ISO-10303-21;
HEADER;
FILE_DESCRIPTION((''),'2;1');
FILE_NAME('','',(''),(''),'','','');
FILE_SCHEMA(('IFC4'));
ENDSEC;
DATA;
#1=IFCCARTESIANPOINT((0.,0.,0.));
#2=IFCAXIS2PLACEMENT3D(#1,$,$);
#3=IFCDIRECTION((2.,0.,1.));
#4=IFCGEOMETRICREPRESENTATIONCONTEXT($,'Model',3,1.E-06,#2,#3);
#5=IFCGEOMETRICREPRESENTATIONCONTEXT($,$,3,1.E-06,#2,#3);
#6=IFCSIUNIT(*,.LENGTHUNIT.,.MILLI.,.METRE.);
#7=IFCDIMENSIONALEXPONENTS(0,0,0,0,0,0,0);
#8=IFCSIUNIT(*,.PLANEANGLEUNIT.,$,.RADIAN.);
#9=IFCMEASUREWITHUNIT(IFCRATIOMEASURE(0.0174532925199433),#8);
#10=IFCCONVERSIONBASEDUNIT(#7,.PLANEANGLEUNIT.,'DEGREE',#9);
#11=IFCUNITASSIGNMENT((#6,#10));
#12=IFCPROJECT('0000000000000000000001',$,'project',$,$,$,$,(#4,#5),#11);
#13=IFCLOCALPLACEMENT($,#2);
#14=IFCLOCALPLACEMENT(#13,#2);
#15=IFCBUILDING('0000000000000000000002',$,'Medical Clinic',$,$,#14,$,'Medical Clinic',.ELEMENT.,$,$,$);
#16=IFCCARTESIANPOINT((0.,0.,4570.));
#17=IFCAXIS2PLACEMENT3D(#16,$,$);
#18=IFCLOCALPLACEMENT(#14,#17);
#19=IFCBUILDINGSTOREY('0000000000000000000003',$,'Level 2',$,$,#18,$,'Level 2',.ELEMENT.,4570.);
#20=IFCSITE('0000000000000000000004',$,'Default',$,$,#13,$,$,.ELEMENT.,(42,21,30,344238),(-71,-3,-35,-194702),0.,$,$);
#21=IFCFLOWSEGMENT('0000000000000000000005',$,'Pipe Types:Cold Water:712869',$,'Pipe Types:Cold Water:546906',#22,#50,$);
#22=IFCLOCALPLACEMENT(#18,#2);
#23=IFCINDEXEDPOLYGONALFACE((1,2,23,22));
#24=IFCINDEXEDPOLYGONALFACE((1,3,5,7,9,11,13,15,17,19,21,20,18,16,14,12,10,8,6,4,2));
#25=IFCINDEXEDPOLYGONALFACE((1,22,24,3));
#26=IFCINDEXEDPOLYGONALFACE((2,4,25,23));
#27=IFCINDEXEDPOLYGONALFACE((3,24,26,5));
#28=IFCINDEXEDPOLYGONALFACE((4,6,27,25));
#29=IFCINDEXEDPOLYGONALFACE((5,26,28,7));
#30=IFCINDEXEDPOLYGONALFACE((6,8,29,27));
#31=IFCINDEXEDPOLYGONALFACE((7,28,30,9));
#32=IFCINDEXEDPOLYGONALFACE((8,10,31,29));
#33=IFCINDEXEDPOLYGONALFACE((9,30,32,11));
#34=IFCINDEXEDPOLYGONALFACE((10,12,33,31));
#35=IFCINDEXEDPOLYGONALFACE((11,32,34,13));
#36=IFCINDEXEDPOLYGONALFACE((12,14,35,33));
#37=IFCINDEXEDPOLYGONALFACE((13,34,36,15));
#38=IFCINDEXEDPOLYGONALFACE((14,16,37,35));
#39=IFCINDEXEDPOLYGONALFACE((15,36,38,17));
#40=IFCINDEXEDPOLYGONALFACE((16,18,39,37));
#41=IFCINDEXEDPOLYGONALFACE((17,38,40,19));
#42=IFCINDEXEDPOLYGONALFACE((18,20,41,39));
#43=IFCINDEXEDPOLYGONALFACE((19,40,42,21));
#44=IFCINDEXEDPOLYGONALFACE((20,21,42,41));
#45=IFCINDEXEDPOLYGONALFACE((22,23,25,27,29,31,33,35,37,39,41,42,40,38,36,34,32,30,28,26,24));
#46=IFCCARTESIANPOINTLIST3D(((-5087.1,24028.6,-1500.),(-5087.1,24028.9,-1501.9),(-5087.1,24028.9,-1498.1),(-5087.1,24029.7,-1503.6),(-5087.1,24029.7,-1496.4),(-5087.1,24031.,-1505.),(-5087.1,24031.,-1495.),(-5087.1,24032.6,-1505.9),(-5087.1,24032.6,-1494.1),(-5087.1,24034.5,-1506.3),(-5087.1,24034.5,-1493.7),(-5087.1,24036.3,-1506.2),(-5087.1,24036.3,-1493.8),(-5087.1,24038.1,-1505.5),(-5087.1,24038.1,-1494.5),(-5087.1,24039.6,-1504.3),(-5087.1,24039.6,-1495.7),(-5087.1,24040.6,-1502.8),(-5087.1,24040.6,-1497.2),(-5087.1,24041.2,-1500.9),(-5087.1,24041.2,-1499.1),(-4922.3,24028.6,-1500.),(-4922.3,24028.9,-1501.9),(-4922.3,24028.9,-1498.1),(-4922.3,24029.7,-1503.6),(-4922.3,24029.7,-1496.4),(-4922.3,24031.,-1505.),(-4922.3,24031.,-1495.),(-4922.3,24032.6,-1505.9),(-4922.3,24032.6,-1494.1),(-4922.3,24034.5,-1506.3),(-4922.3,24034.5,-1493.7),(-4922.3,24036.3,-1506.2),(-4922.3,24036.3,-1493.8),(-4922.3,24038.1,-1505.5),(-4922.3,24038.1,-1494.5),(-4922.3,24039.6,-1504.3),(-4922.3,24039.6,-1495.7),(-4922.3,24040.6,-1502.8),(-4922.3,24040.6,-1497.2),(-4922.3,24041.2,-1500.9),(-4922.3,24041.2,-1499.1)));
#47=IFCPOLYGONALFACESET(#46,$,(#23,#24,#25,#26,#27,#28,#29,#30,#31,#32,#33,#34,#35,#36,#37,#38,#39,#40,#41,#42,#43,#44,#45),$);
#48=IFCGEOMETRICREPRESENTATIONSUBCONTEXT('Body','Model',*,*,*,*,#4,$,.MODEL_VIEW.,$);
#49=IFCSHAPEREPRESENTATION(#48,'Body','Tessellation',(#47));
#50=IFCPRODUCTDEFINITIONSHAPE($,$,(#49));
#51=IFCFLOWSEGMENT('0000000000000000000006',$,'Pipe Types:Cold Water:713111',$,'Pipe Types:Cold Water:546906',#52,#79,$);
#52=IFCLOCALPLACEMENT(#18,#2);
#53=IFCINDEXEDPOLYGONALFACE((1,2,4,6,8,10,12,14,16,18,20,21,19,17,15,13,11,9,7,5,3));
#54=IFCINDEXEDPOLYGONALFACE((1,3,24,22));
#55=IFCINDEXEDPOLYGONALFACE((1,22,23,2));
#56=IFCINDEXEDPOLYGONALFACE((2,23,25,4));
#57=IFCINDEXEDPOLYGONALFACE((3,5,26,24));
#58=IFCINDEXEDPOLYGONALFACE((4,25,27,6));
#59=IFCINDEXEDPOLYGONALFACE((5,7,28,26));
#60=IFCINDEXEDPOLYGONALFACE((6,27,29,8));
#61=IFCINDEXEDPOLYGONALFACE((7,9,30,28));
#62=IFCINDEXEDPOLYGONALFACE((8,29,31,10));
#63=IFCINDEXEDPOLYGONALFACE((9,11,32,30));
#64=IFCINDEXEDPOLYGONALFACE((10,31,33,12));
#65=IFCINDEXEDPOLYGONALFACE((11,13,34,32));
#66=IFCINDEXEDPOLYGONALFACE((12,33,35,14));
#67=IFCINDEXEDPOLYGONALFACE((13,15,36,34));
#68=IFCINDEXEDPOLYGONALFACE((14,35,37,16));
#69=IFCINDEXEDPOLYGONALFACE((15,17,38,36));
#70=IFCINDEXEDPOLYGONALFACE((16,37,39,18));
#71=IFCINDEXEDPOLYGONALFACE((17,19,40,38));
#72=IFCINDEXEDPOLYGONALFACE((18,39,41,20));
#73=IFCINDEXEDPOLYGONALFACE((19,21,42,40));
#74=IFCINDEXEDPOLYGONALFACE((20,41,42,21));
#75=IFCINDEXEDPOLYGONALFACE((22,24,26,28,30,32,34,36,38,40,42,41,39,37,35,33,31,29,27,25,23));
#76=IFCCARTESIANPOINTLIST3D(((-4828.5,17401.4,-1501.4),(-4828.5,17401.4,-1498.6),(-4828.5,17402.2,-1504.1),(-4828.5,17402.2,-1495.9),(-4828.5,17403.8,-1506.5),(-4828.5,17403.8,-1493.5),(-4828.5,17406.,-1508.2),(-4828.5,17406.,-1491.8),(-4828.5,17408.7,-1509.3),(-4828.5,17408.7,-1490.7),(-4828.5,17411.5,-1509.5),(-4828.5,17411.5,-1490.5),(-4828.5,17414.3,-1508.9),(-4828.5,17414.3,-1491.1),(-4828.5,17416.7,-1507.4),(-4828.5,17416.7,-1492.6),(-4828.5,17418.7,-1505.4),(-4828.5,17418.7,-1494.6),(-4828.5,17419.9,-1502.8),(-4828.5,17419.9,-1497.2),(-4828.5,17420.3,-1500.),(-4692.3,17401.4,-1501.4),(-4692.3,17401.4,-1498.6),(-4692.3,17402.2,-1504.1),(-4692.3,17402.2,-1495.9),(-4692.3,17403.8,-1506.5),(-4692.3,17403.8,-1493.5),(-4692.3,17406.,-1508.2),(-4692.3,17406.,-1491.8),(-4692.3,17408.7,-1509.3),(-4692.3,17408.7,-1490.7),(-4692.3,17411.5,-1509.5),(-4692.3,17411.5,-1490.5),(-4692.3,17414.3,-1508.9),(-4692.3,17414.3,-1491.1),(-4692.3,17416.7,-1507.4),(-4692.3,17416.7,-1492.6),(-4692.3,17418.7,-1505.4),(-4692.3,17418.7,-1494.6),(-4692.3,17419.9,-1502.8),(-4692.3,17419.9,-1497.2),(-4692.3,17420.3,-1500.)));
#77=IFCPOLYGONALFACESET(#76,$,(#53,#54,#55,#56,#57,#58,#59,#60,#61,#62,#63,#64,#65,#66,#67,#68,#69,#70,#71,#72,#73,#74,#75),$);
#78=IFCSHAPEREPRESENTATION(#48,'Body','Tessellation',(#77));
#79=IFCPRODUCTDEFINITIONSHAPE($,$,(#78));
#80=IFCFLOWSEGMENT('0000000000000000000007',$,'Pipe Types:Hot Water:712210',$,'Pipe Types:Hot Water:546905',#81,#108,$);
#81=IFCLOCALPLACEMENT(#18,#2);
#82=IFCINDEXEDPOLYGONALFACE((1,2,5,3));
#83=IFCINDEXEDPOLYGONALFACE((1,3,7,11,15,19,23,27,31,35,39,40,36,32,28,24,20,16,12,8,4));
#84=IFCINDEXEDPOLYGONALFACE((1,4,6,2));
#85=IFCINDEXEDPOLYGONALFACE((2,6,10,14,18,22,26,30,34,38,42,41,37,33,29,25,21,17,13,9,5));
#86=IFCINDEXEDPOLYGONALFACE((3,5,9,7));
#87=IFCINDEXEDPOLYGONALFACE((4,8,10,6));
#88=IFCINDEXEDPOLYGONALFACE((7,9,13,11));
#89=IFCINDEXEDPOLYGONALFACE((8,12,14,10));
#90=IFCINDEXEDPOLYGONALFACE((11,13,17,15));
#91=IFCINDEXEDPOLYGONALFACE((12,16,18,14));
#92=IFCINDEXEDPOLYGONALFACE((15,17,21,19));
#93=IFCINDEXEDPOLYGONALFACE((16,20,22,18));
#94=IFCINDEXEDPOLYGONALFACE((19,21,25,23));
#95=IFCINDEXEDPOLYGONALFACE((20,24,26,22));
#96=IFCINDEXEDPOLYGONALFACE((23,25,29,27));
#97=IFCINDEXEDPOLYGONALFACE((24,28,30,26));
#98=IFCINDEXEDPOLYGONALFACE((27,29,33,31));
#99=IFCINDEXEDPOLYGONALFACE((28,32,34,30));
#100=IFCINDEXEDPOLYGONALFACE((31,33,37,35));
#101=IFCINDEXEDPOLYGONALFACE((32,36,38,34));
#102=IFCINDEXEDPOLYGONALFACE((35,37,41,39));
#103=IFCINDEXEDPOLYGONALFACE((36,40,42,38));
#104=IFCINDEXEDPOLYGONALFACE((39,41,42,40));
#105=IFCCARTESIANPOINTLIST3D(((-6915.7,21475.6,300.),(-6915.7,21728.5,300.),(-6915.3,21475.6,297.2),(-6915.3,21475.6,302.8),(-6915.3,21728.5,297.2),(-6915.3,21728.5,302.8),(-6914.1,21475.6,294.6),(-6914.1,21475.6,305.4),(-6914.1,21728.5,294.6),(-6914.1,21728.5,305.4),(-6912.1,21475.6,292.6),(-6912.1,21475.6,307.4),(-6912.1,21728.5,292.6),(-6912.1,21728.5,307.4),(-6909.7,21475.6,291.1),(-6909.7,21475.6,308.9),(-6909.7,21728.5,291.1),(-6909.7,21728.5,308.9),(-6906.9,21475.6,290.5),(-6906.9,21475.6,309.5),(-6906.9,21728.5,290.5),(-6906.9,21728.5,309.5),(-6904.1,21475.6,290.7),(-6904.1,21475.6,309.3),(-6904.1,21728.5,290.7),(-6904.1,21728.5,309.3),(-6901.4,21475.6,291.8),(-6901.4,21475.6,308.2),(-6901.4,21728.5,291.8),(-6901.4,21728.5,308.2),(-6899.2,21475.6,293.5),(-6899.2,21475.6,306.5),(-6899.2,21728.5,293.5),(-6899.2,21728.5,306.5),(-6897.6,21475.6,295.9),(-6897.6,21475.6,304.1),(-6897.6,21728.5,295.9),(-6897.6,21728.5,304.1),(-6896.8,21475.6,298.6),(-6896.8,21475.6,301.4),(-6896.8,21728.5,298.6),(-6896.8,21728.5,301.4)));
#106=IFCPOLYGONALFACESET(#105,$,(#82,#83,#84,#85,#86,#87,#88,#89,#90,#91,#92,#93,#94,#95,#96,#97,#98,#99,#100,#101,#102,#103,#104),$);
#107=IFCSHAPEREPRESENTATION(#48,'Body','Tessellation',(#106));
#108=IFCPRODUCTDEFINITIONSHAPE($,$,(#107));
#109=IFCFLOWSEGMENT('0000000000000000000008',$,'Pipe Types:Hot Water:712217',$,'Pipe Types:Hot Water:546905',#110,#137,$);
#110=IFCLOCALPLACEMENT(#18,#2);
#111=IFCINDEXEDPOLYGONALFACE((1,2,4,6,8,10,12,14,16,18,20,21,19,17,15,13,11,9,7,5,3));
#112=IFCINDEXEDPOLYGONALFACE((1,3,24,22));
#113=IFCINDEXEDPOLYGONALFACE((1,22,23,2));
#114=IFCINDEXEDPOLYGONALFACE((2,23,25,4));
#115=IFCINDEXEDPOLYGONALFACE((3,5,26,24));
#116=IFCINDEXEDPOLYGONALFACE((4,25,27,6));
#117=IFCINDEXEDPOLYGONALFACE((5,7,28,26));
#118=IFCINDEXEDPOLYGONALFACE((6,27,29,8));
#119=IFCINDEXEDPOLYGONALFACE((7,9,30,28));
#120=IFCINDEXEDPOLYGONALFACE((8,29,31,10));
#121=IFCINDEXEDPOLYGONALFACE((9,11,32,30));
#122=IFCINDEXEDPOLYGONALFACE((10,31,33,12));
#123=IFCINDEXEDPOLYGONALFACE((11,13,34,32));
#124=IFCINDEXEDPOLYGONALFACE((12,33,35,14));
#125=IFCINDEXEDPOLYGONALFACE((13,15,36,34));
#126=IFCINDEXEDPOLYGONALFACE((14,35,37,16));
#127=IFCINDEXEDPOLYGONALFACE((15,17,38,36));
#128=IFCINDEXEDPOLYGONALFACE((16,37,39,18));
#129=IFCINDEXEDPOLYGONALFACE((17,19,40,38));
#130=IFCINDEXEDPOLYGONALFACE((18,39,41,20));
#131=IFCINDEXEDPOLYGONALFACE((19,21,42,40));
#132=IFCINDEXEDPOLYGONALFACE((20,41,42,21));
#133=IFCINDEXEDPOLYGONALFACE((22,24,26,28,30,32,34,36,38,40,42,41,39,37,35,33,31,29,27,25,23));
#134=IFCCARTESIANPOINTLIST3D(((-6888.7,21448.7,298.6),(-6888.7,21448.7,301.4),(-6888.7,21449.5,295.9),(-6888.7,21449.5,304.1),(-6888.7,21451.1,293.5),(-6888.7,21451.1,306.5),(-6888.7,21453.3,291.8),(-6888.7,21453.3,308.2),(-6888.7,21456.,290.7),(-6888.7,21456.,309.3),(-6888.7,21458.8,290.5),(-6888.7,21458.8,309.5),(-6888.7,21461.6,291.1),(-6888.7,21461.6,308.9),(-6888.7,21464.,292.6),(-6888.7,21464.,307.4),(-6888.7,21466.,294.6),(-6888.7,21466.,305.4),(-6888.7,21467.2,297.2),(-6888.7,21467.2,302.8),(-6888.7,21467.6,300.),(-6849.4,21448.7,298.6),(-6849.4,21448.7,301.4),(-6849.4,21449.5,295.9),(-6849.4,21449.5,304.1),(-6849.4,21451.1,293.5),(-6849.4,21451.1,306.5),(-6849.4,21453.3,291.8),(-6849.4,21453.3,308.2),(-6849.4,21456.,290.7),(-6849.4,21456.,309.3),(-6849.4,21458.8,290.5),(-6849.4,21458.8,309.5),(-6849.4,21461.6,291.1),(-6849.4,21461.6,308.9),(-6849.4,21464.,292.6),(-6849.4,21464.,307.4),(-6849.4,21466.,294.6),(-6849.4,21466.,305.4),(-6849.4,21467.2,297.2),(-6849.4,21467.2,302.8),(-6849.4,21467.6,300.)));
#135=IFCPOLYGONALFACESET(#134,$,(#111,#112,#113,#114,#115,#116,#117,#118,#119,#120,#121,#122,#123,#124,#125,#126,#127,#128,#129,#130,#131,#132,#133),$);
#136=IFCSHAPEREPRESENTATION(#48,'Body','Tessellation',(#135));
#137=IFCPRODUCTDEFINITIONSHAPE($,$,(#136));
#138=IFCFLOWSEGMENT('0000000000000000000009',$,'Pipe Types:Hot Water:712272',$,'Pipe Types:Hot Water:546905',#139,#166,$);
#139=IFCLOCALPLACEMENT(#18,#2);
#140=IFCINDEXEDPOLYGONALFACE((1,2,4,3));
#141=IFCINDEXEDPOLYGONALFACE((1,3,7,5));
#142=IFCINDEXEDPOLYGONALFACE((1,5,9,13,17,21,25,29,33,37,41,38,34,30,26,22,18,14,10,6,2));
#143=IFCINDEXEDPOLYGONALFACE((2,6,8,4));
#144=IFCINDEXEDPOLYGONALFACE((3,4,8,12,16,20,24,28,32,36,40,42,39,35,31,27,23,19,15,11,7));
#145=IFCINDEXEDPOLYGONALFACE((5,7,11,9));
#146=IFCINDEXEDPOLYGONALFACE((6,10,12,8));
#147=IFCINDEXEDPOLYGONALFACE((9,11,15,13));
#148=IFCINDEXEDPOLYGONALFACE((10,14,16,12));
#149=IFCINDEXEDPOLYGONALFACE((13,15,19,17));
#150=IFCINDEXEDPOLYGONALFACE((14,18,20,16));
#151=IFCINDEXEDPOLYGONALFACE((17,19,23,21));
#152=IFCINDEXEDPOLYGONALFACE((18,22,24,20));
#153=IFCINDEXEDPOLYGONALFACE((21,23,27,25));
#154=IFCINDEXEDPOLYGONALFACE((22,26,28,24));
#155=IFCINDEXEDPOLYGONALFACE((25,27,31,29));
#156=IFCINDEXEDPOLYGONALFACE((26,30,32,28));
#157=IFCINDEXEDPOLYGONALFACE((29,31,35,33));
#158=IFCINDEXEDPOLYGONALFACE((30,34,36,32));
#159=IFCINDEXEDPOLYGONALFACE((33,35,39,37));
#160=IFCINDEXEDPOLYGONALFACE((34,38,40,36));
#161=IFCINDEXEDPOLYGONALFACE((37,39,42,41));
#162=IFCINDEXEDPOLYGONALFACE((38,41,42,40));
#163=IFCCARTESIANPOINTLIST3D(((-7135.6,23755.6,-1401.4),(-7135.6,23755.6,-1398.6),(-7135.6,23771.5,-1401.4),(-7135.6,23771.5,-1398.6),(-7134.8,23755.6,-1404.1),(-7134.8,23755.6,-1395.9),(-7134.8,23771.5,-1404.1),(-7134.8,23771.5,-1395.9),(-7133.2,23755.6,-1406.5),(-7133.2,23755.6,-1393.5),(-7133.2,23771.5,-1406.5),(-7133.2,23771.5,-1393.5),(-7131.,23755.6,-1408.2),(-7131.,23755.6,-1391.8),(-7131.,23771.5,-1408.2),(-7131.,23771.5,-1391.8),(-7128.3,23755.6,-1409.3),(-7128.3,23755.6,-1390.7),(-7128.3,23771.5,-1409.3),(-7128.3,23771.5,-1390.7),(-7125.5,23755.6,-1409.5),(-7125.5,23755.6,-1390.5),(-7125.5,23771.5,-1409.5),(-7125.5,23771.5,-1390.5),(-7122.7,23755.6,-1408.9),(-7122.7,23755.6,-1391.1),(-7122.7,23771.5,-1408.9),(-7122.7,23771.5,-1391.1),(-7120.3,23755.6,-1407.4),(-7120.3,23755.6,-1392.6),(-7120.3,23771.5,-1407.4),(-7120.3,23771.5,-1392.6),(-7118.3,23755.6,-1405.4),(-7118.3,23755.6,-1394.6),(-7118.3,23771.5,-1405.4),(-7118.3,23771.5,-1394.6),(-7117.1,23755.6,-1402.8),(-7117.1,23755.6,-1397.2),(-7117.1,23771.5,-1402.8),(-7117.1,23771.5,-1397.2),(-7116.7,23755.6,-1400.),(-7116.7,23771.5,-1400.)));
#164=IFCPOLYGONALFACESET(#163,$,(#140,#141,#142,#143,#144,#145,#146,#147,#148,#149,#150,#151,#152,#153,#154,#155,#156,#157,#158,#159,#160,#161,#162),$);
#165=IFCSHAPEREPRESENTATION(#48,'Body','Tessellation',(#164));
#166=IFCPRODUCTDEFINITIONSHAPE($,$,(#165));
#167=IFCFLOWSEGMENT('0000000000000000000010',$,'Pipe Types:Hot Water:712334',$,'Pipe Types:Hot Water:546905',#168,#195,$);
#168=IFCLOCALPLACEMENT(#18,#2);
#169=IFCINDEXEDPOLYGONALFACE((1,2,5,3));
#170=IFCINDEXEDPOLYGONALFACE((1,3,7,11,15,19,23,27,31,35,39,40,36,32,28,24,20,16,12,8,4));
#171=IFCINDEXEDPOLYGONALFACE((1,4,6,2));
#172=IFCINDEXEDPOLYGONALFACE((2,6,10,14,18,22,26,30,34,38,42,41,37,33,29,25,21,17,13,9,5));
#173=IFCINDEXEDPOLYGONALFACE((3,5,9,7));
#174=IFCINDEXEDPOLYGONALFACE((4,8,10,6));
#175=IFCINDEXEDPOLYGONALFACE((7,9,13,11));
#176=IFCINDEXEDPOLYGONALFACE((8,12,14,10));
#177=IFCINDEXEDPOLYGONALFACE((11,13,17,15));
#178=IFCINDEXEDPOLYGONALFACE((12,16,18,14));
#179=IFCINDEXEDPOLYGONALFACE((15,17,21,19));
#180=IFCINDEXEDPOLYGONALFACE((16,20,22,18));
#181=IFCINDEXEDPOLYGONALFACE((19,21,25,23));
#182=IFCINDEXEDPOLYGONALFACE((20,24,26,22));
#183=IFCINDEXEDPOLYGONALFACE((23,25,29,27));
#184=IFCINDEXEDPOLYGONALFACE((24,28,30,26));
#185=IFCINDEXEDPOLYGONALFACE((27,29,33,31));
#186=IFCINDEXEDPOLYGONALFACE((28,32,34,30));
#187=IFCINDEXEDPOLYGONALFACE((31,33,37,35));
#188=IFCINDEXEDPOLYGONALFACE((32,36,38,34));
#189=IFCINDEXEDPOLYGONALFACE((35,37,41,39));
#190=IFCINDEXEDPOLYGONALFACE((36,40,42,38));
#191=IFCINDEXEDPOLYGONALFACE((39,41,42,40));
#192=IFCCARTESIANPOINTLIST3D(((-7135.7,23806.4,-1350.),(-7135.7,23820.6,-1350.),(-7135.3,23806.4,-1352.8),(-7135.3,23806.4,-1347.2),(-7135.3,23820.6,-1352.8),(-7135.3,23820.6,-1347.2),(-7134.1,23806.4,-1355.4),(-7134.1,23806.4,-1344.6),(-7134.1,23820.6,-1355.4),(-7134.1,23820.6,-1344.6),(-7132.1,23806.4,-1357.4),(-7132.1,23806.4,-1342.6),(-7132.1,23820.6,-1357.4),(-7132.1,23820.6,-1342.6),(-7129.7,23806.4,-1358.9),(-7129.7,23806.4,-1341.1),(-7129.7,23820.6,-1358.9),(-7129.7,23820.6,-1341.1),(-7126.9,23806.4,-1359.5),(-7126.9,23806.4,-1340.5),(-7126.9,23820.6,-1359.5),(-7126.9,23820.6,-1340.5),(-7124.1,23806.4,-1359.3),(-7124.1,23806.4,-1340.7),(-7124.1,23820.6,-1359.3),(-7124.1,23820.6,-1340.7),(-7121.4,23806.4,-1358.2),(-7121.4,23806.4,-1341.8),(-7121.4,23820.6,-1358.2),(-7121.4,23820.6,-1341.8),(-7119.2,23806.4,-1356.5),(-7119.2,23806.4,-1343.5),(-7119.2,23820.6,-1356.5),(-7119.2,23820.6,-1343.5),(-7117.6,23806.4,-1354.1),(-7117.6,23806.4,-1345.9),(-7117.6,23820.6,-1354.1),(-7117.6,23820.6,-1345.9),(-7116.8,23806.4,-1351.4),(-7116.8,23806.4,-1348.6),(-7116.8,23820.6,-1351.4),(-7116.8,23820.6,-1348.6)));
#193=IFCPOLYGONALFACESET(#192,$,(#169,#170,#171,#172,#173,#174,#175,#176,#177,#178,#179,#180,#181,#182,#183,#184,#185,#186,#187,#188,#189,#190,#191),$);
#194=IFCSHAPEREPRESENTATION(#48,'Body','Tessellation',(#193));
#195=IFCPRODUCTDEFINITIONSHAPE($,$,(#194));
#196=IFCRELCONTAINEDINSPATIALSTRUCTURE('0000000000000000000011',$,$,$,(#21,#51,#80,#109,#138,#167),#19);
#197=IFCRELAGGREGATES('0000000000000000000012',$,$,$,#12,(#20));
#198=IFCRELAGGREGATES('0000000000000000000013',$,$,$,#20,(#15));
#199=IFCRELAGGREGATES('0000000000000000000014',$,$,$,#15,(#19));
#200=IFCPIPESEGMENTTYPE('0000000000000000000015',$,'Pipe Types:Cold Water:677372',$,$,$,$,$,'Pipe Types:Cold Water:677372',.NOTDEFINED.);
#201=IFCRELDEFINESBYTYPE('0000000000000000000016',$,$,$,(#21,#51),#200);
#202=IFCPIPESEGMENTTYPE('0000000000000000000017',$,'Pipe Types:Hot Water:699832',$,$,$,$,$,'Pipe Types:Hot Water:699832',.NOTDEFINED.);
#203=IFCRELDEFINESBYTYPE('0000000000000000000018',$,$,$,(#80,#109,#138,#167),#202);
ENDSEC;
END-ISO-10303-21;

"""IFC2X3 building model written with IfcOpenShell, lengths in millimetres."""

from ifc_helpers import new_model, entity, si_unit, converted_unit, direction, frame, frame_2d, origin, origin_2d_with_axis, place, context, subcontext, project, spatial, circle, extrude, type_object, element, save


model = new_model("IFC2X3")

# Units and contexts
model_context = context("Model", 3, precision=1e-06, world=origin(), true_north=direction((2.0, 0.0, 1.0)))
context_of_model = context(None, 3, precision=1e-06, world=origin(), true_north=direction((2.0, 0.0, 1.0)))
body_context = subcontext(model_context, "Body", "Model", "MODEL_VIEW")
ifc_project = project(units=[si_unit("LENGTHUNIT", "METRE", prefix="MILLI"), converted_unit("PLANEANGLEUNIT", "DEGREE", entity("IfcRatioMeasure", 0.0174532925199433), si_unit("PLANEANGLEUNIT", "RADIAN"), dimensions=[0, 0, 0, 0, 0, 0, 0])], contexts=[model_context, context_of_model])

# Site, building, storey
site_placement = place(None, origin())
site = spatial("IfcSite", under=ifc_project, at=site_placement, Name="Default", CompositionType="ELEMENT", RefLatitude=(42, 21, 30, 344238), RefLongitude=(-71, -3, -35, -194702), RefElevation=0.0)
building_placement = place(site_placement, origin())
building = spatial("IfcBuilding", under=site, at=building_placement, Name="Medical Clinic", LongName="Medical Clinic", CompositionType="ELEMENT")
storey_placement = place(building_placement, frame((0.0, 0.0, 4570.0)))
storey = spatial("IfcBuildingStorey", under=building, at=storey_placement, Name="Level 2", LongName="Level 2", CompositionType="ELEMENT", Elevation=4570.0)

# Flow segments
pipe_segment_type_1 = type_object("IfcPipeSegmentType", Name="Pipe Types:Cold Water:677372", ElementType="Pipe Types:Cold Water:677372", PredefinedType="NOTDEFINED")
flow_segment_1_placement = place(storey_placement, origin())
element("IfcFlowSegment", 1, at=flow_segment_1_placement, inside=storey, type_object=pipe_segment_type_1, Name="Pipe Types:Cold Water:712869", ObjectType="Pipe Types:Cold Water:546906", context=body_context, shape_type="SweptSolid", body=[
    extrude(circle(Radius=6.3, at=origin_2d_with_axis()), frame((-5087.1, 24034.9, -1500.0), z_axis=(1.0, 0.0, 0.0), x_axis=(0.0, -1.0, 0.0)), (0.0, 0.0, 1.0), 164.8),
])
flow_segment_2_placement = place(storey_placement, origin())
element("IfcFlowSegment", 2, at=flow_segment_2_placement, inside=storey, type_object=pipe_segment_type_1, Name="Pipe Types:Cold Water:713111", ObjectType="Pipe Types:Cold Water:546906", context=body_context, shape_type="SweptSolid", body=[
    extrude(circle(Radius=9.5, at=frame_2d((0.0, 0.0), x_axis=(1.0, 0.0))), frame((-4828.5, 17410.8, -1500.0), z_axis=(1.0, 0.0, 0.0), x_axis=(0.0, 1.0, 0.0)), (0.0, 0.0, 1.0), 136.2),
])
pipe_segment_type_2 = type_object("IfcPipeSegmentType", Name="Pipe Types:Hot Water:699832", ElementType="Pipe Types:Hot Water:699832", PredefinedType="NOTDEFINED")
flow_segment_3_placement = place(storey_placement, origin())
element("IfcFlowSegment", 3, at=flow_segment_3_placement, inside=storey, type_object=pipe_segment_type_2, Name="Pipe Types:Hot Water:712210", ObjectType="Pipe Types:Hot Water:546905", context=body_context, shape_type="SweptSolid", body=[
    extrude(circle(Radius=9.5, at=frame_2d((0.0, 0.0), x_axis=(1.0, 0.0))), frame((-6906.2, 21475.6, 300.0), z_axis=(0.0, 1.0, 0.0), x_axis=(-1.0, 0.0, 0.0)), (0.0, 0.0, 1.0), 253.0),
])
flow_segment_4_placement = place(storey_placement, origin())
element("IfcFlowSegment", 4, at=flow_segment_4_placement, inside=storey, type_object=pipe_segment_type_2, Name="Pipe Types:Hot Water:712217", ObjectType="Pipe Types:Hot Water:546905", context=body_context, shape_type="SweptSolid", body=[
    extrude(circle(Radius=9.5, at=frame_2d((0.0, 0.0), x_axis=(1.0, 0.0))), frame((-6888.7, 21458.1, 300.0), z_axis=(1.0, 0.0, 0.0), x_axis=(0.0, 1.0, 0.0)), (0.0, 0.0, 1.0), 39.4),
])
flow_segment_5_placement = place(storey_placement, origin())
element("IfcFlowSegment", 5, at=flow_segment_5_placement, inside=storey, type_object=pipe_segment_type_2, Name="Pipe Types:Hot Water:712272", ObjectType="Pipe Types:Hot Water:546905", context=body_context, shape_type="SweptSolid", body=[
    extrude(circle(Radius=9.5, at=origin_2d_with_axis()), frame((-7126.2, 23755.6, -1400.0), z_axis=(0.0, 1.0, 0.0), x_axis=(1.0, 0.0, 0.0)), (0.0, 0.0, 1.0), 15.9),
])
flow_segment_6_placement = place(storey_placement, origin())
element("IfcFlowSegment", 6, at=flow_segment_6_placement, inside=storey, type_object=pipe_segment_type_2, Name="Pipe Types:Hot Water:712334", ObjectType="Pipe Types:Hot Water:546905", context=body_context, shape_type="SweptSolid", body=[
    extrude(circle(Radius=9.5, at=frame_2d((0.0, 0.0), x_axis=(1.0, 0.0))), frame((-7126.2, 23806.4, -1350.0), z_axis=(0.0, 1.0, 0.0), x_axis=(-1.0, 0.0, 0.0)), (0.0, 0.0, 1.0), 14.2),
])

save(model, "model.ifc")
